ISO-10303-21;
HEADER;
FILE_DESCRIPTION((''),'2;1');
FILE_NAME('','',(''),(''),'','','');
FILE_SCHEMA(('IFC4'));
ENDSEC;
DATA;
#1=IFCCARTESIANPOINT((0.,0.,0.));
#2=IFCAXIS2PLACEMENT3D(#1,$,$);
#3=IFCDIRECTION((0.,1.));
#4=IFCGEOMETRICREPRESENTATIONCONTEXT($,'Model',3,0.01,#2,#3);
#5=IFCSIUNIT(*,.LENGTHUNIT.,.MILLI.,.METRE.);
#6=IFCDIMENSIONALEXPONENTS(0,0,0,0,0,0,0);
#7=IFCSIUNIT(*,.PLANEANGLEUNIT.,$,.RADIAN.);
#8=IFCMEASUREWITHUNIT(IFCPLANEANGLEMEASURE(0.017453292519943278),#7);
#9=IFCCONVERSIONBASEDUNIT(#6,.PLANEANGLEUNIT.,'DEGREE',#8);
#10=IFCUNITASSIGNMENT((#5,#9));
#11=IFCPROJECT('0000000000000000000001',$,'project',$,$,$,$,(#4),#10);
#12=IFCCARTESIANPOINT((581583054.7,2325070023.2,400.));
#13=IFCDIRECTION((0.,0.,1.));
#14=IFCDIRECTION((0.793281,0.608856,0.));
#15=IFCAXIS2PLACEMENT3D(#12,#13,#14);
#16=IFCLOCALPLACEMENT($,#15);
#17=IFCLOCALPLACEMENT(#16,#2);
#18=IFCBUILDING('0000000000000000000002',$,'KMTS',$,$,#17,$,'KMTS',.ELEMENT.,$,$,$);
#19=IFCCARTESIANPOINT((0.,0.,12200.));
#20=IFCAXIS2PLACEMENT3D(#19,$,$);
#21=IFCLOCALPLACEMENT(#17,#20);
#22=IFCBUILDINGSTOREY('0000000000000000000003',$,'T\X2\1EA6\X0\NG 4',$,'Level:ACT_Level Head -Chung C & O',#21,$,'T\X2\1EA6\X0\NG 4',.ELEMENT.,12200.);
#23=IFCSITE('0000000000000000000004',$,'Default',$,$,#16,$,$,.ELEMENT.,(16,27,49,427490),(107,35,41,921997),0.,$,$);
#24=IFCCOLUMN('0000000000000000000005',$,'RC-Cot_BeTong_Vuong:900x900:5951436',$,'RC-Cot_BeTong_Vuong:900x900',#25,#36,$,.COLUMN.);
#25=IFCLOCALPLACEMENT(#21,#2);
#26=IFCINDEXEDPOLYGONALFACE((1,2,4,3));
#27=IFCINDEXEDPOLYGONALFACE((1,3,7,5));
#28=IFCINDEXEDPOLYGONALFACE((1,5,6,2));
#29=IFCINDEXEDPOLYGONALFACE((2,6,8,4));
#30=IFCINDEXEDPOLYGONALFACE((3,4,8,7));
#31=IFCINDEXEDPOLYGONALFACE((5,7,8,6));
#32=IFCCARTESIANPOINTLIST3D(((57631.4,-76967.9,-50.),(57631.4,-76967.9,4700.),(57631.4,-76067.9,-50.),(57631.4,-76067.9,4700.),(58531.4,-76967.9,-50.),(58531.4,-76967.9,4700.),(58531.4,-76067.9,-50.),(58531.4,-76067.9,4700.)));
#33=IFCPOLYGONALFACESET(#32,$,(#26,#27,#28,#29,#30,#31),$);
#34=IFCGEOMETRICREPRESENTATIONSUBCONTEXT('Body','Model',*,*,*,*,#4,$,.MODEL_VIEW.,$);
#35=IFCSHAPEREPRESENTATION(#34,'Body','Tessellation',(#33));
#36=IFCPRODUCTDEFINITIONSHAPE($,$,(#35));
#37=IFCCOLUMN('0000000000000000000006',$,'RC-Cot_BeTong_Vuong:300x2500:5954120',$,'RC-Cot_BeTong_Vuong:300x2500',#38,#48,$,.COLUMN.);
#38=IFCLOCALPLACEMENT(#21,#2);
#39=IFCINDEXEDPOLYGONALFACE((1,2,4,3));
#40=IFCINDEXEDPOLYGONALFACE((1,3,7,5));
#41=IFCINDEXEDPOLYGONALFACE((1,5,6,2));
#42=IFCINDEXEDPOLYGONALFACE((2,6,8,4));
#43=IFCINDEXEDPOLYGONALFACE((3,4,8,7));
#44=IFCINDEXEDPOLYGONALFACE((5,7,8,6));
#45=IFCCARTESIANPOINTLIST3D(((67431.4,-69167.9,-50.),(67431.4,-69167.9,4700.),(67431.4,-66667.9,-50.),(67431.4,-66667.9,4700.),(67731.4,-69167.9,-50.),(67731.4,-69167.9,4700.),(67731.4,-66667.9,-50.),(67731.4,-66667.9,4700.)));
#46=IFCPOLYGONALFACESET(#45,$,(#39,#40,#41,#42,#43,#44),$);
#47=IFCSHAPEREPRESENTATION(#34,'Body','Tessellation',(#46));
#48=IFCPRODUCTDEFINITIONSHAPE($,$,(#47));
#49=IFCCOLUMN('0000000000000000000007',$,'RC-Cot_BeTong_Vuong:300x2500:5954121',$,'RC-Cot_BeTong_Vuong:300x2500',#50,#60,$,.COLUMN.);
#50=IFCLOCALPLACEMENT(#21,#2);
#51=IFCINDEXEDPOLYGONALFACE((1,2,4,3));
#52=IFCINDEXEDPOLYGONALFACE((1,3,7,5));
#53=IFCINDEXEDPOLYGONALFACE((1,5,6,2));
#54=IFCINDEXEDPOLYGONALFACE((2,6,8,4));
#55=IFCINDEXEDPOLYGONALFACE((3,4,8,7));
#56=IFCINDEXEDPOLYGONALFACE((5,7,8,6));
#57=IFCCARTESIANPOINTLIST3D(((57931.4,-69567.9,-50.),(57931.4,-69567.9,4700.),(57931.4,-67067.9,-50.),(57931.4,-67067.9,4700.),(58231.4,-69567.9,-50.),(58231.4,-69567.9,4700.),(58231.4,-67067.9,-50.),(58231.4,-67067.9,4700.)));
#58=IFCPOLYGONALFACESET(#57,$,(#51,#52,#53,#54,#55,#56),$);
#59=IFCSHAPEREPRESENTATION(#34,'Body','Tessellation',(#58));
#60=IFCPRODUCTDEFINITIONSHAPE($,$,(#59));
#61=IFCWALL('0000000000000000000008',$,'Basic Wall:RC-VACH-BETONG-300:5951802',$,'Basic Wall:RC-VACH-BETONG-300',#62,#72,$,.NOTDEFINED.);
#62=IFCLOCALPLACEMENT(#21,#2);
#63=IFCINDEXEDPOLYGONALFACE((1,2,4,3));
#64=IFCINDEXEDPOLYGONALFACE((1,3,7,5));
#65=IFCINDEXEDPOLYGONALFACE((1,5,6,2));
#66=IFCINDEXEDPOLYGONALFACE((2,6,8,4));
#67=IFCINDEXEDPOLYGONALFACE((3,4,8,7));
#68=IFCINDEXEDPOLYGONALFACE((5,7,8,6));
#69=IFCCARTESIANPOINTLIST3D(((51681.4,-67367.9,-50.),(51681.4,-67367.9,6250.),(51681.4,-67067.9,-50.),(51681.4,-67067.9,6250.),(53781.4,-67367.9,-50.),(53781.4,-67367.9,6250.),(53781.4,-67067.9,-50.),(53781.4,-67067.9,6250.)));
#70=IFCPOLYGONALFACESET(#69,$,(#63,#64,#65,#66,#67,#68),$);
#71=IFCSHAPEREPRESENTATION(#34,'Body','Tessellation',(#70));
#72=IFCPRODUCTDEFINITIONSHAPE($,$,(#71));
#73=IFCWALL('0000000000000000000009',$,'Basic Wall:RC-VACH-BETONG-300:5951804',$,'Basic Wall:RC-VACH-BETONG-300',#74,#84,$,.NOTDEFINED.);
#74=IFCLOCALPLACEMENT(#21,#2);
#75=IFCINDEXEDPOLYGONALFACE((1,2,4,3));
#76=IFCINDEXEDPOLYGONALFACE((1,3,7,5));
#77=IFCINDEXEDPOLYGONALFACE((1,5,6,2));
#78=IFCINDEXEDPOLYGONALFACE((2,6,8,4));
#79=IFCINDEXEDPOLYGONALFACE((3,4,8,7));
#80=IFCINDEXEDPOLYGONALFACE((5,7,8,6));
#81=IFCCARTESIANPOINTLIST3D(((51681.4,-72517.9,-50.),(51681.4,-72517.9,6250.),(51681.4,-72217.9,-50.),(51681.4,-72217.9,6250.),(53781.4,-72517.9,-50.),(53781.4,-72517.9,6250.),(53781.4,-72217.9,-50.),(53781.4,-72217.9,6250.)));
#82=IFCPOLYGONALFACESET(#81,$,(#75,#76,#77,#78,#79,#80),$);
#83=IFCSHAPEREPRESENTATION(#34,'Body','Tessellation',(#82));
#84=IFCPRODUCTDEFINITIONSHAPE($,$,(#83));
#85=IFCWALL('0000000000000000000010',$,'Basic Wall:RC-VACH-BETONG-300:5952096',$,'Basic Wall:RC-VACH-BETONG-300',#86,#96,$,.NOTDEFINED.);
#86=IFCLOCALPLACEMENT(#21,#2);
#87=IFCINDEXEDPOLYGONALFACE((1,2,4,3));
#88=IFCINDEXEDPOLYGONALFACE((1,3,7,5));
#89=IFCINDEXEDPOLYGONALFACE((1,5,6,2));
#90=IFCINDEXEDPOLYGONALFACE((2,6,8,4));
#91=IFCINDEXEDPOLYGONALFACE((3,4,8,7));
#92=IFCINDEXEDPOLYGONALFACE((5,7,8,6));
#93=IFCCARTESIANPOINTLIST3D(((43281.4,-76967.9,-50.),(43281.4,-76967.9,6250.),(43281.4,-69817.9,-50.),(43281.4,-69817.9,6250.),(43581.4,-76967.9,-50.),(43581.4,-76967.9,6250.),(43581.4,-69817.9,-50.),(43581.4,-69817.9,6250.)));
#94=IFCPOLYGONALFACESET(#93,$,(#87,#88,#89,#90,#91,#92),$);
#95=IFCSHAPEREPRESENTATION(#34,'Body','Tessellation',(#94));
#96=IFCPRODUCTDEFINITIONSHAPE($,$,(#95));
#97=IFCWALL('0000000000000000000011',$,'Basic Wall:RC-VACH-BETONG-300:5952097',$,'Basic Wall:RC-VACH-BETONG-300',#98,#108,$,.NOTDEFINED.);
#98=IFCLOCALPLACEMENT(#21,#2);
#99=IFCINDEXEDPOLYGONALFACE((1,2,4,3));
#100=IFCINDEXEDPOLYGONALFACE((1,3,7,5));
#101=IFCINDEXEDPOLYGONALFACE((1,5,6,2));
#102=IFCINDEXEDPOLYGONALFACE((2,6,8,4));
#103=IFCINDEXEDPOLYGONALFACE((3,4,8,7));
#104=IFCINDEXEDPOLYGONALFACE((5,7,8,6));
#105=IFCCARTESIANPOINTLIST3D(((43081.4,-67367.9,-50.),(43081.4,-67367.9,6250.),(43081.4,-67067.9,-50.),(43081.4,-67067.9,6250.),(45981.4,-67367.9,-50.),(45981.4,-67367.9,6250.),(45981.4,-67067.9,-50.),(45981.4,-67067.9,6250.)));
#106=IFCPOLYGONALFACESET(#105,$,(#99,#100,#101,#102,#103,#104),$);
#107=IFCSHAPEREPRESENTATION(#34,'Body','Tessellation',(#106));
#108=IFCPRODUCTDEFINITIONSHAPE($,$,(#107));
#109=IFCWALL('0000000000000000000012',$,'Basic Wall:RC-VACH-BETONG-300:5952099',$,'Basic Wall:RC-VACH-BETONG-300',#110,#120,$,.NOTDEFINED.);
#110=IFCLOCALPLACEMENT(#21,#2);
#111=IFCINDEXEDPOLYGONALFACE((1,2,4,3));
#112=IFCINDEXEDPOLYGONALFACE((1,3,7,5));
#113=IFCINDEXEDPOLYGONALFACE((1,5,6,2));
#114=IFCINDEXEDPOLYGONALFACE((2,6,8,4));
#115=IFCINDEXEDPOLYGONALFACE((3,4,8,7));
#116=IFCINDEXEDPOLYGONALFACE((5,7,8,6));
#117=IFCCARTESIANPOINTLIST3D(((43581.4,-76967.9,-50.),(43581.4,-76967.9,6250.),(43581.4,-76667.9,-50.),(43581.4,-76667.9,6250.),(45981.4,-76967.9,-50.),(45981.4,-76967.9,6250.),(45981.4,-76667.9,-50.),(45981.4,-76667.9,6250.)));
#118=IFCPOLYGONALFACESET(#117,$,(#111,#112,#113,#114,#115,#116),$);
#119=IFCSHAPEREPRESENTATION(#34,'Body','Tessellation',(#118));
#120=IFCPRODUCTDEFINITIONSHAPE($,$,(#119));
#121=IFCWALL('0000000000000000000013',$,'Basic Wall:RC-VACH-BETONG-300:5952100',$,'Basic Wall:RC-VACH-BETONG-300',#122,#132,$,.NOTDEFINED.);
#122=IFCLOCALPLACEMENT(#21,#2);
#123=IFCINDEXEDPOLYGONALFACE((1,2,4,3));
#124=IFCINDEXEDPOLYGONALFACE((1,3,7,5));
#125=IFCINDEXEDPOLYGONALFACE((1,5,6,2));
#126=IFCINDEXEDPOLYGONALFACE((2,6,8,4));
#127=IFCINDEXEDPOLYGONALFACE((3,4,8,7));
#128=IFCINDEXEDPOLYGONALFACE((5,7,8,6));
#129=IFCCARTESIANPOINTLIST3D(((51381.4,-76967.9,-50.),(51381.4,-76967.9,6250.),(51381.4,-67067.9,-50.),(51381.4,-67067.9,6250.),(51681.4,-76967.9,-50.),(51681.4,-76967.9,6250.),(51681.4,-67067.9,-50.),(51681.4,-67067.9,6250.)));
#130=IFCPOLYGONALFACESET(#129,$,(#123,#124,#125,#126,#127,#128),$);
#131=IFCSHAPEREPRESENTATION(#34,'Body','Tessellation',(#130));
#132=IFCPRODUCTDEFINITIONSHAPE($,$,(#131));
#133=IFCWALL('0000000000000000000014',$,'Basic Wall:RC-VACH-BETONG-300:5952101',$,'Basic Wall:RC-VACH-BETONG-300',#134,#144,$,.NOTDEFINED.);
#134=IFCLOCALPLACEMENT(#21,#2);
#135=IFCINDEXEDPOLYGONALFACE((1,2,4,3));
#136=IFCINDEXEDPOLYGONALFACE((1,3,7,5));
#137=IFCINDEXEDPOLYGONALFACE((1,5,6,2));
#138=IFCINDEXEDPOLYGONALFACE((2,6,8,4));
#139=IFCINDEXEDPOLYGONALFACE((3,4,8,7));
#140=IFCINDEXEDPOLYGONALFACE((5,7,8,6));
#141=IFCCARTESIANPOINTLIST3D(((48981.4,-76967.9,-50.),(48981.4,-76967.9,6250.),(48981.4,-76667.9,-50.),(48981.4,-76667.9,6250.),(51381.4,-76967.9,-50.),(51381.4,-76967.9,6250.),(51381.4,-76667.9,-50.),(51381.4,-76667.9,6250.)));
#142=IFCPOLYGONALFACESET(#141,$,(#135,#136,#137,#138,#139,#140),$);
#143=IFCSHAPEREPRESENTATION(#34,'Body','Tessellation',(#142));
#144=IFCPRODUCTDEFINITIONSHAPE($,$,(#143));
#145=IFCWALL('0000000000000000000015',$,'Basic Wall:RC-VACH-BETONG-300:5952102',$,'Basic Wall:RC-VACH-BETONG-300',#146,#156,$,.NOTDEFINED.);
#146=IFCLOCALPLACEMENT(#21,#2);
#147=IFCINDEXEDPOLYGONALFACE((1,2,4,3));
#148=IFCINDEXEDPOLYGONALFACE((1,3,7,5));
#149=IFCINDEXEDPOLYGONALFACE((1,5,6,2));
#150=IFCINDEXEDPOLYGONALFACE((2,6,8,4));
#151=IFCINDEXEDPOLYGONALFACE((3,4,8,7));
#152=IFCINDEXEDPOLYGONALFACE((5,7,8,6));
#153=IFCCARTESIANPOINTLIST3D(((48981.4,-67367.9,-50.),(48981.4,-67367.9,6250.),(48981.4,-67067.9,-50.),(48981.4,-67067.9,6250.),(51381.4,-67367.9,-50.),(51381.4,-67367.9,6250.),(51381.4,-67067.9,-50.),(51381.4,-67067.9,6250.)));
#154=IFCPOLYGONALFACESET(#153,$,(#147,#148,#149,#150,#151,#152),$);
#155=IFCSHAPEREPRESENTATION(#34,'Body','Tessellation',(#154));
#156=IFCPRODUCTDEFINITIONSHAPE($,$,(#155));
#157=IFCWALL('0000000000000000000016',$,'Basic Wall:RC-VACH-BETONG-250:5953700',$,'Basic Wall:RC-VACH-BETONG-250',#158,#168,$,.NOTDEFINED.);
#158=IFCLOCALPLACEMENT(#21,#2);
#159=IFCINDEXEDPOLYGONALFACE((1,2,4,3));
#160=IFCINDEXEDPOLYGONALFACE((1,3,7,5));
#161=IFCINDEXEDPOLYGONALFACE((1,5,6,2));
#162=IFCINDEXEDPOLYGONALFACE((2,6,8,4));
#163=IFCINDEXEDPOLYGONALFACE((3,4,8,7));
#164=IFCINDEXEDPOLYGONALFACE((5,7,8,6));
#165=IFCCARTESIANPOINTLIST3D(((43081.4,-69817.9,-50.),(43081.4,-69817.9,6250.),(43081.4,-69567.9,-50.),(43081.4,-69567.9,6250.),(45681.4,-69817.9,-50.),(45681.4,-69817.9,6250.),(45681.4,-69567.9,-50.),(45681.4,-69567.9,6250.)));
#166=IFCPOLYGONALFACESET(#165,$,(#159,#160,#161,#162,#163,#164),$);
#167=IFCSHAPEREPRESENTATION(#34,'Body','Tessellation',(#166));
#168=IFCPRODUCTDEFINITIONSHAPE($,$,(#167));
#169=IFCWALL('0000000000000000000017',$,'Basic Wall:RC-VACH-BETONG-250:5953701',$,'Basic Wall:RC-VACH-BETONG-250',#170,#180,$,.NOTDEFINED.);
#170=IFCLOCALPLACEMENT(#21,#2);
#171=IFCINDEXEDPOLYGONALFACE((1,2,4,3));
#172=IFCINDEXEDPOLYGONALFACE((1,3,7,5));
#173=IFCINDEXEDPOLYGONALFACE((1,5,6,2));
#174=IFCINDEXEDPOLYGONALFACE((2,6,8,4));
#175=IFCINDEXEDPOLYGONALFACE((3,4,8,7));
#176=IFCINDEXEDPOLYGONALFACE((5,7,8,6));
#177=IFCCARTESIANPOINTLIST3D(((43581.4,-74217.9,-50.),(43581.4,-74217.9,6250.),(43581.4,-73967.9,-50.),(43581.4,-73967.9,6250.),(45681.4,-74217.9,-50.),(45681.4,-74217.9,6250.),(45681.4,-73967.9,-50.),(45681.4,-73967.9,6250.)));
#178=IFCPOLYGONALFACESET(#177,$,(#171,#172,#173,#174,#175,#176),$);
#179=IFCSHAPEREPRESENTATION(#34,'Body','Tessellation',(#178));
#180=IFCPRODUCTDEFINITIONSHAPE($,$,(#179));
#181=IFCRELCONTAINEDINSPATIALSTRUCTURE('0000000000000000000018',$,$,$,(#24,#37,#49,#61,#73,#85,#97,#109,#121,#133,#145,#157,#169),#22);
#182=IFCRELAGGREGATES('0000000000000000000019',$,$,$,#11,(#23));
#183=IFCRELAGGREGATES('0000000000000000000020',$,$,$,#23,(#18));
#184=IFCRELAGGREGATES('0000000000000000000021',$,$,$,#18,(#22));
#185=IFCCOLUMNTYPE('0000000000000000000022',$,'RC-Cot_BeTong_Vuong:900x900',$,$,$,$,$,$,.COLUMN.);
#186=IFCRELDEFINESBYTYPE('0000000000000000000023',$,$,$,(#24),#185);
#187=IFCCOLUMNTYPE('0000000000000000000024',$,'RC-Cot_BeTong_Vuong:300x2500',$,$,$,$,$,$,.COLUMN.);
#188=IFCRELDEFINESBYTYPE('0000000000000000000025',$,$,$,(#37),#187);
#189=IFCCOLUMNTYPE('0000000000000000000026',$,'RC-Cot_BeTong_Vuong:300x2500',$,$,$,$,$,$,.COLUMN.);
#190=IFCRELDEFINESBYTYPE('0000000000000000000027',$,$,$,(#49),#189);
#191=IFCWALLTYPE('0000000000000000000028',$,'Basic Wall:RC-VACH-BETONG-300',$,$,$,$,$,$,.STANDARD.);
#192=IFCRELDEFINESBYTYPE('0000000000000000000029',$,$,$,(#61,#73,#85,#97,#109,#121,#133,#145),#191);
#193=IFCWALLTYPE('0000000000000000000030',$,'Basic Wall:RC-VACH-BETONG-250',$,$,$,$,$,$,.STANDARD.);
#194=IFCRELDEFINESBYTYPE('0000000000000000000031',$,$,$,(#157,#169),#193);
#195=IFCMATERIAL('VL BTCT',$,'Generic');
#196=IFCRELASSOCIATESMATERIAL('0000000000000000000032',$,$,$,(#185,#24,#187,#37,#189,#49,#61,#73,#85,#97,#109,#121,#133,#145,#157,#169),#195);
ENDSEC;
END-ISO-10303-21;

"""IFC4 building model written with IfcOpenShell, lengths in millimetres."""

from ifc_helpers import new_model, entity, si_unit, converted_unit, direction, frame, origin, place, context, subcontext, project, spatial, indexed_curve, outline, extrude, source, transform, mapped, material, type_object, type_shapes, element, save


model = new_model("IFC4")

# Units and contexts
model_context = context("Model", 3, precision=0.01, world=origin(), true_north=direction((0.0, 1.0)))
body_context = subcontext(model_context, "Body", "Model", "MODEL_VIEW")
ifc_project = project(units=[si_unit("LENGTHUNIT", "METRE", prefix="MILLI"), converted_unit("PLANEANGLEUNIT", "DEGREE", entity("IfcPlaneAngleMeasure", 0.017453292519943278), si_unit("PLANEANGLEUNIT", "RADIAN"), dimensions=[0, 0, 0, 0, 0, 0, 0])], contexts=[model_context])

# Site, building, storey
site_placement = place(None, frame((581583054.7, 2325070023.2, 400.0), z_axis=(0.0, 0.0, 1.0), x_axis=(0.793281, 0.608856, 0.0)))
site = spatial("IfcSite", under=ifc_project, at=site_placement, Name="Default", CompositionType="ELEMENT", RefLatitude=(16, 27, 49, 427490), RefLongitude=(107, 35, 41, 921997), RefElevation=0.0)
building_placement = place(site_placement, origin())
building = spatial("IfcBuilding", under=site, at=building_placement, Name="KMTS", LongName="KMTS", CompositionType="ELEMENT")
storey_placement = place(building_placement, frame((0.0, 0.0, 12200.0)))
storey = spatial("IfcBuildingStorey", under=building, at=storey_placement, Name="TẦNG 4", ObjectType="Level:ACT_Level Head -Chung C & O", LongName="TẦNG 4", CompositionType="ELEMENT", Elevation=12200.0)

# Columns
ifc_material_1 = material(Name="VL BTCT", Category="Generic")
column_type_1 = type_object("IfcColumnType", Name="RC-Cot_BeTong_Vuong:900x900", PredefinedType="COLUMN", material=ifc_material_1)
shared_shape_1 = source(origin(), body_context, "Body", "SweptSolid", [
    extrude(outline(indexed_curve([(-450.0, -450.0), (450.0, -450.0), (450.0, 450.0), (-450.0, 450.0), (-450.0, -450.0)], self_intersect=False)), frame((58081.4, -76517.9, 12150.0), z_axis=(0.0, 0.0, 1.0), x_axis=(-1.0, 0.0, 0.0)), (0.0, 0.0, 1.0), 4750.0),
])
type_shapes(column_type_1, [shared_shape_1])
column_1_placement = place(storey_placement, frame((0.0, 0.0, -12200.0)))
element("IfcColumn", 1, at=column_1_placement, inside=storey, type_object=column_type_1, material=ifc_material_1, Name="RC-Cot_BeTong_Vuong:900x900:5951436", ObjectType="RC-Cot_BeTong_Vuong:900x900", PredefinedType="COLUMN", context=body_context, shape_type="MappedRepresentation", body=[
    mapped(shared_shape_1, transform((0.0, 0.0, 0.0), scale=1.0)),
])
column_type_2 = type_object("IfcColumnType", Name="RC-Cot_BeTong_Vuong:300x2500", PredefinedType="COLUMN", material=ifc_material_1)
shared_shape_2 = source(origin(), body_context, "Body", "SweptSolid", [
    extrude(outline(indexed_curve([(-150.0, -1250.0), (150.0, -1250.0), (150.0, 1250.0), (-150.0, 1250.0), (-150.0, -1250.0)], self_intersect=False)), frame((67581.4, -67917.9, 12150.0), z_axis=(0.0, 0.0, 1.0), x_axis=(-1.0, 0.0, 0.0)), (0.0, 0.0, 1.0), 4750.0),
])
type_shapes(column_type_2, [shared_shape_2])
column_2_placement = place(storey_placement, frame((0.0, 0.0, -12200.0)))
element("IfcColumn", 2, at=column_2_placement, inside=storey, type_object=column_type_2, material=ifc_material_1, Name="RC-Cot_BeTong_Vuong:300x2500:5954120", ObjectType="RC-Cot_BeTong_Vuong:300x2500", PredefinedType="COLUMN", context=body_context, shape_type="MappedRepresentation", body=[
    mapped(shared_shape_2, transform((0.0, 0.0, 0.0), scale=1.0)),
])
column_type_3 = type_object("IfcColumnType", Name="RC-Cot_BeTong_Vuong:300x2500", PredefinedType="COLUMN", material=ifc_material_1)
shared_shape_3 = source(origin(), body_context, "Body", "SweptSolid", [
    extrude(outline(indexed_curve([(-150.0, -1250.0), (150.0, -1250.0), (150.0, 1250.0), (-150.0, 1250.0), (-150.0, -1250.0)], self_intersect=False)), frame((58081.4, -68317.9, 12150.0), z_axis=(0.0, 0.0, 1.0), x_axis=(-1.0, 0.0, 0.0)), (0.0, 0.0, 1.0), 4750.0),
])
type_shapes(column_type_3, [shared_shape_3])
column_3_placement = place(storey_placement, frame((0.0, 0.0, -12200.0)))
element("IfcColumn", 3, at=column_3_placement, inside=storey, type_object=column_type_3, material=ifc_material_1, Name="RC-Cot_BeTong_Vuong:300x2500:5954121", ObjectType="RC-Cot_BeTong_Vuong:300x2500", PredefinedType="COLUMN", context=body_context, shape_type="MappedRepresentation", body=[
    mapped(shared_shape_3, transform((0.0, 0.0, 0.0), scale=1.0)),
])

# Walls
wall_type_1 = type_object("IfcWallType", Name="Basic Wall:RC-VACH-BETONG-300", PredefinedType="STANDARD")
wall_1_placement = place(storey_placement, frame((53781.4, -67217.9, -50.0), z_axis=(0.0, 0.0, 1.0), x_axis=(-1.0, 0.0, 0.0)))
element("IfcWall", 4, at=wall_1_placement, inside=storey, type_object=wall_type_1, material=ifc_material_1, Name="Basic Wall:RC-VACH-BETONG-300:5951802", ObjectType="Basic Wall:RC-VACH-BETONG-300", PredefinedType="NOTDEFINED", context=body_context, shape_type="SweptSolid", body=[
    extrude(outline(indexed_curve([(2100.0, 150.0), (0.0, 150.0), (0.0, -150.0), (2100.0, -150.0), (2100.0, 150.0)], self_intersect=False)), origin(), (0.0, 0.0, 1.0), 6300.0),
])
wall_2_placement = place(storey_placement, frame((53781.4, -72367.9, -50.0), z_axis=(0.0, 0.0, 1.0), x_axis=(-1.0, 0.0, 0.0)))
element("IfcWall", 5, at=wall_2_placement, inside=storey, type_object=wall_type_1, material=ifc_material_1, Name="Basic Wall:RC-VACH-BETONG-300:5951804", ObjectType="Basic Wall:RC-VACH-BETONG-300", PredefinedType="NOTDEFINED", context=body_context, shape_type="SweptSolid", body=[
    extrude(outline(indexed_curve([(2100.0, 150.0), (0.0, 150.0), (0.0, -150.0), (2100.0, -150.0), (2100.0, 150.0)], self_intersect=False)), origin(), (0.0, 0.0, 1.0), 6300.0),
])
wall_3_placement = place(storey_placement, frame((43431.4, -69817.9, -50.0), z_axis=(0.0, 0.0, 1.0), x_axis=(0.0, -1.0, 0.0)))
element("IfcWall", 6, at=wall_3_placement, inside=storey, type_object=wall_type_1, material=ifc_material_1, Name="Basic Wall:RC-VACH-BETONG-300:5952096", ObjectType="Basic Wall:RC-VACH-BETONG-300", PredefinedType="NOTDEFINED", context=body_context, shape_type="SweptSolid", body=[
    extrude(outline(indexed_curve([(7150.0, 150.0), (0.0, 150.0), (0.0, -150.0), (7150.0, -150.0), (7150.0, 150.0)], self_intersect=False)), origin(), (0.0, 0.0, 1.0), 6300.0),
])
wall_4_placement = place(storey_placement, frame((45981.4, -67217.9, -50.0), z_axis=(0.0, 0.0, 1.0), x_axis=(-1.0, 0.0, 0.0)))
element("IfcWall", 7, at=wall_4_placement, inside=storey, type_object=wall_type_1, material=ifc_material_1, Name="Basic Wall:RC-VACH-BETONG-300:5952097", ObjectType="Basic Wall:RC-VACH-BETONG-300", PredefinedType="NOTDEFINED", context=body_context, shape_type="SweptSolid", body=[
    extrude(outline(indexed_curve([(2900.0, 150.0), (0.0, 150.0), (0.0, -150.0), (2900.0, -150.0), (2900.0, 150.0)], self_intersect=False)), origin(), (0.0, 0.0, 1.0), 6300.0),
])
wall_5_placement = place(storey_placement, frame((45981.4, -76817.9, -50.0), z_axis=(0.0, 0.0, 1.0), x_axis=(-1.0, 0.0, 0.0)))
element("IfcWall", 8, at=wall_5_placement, inside=storey, type_object=wall_type_1, material=ifc_material_1, Name="Basic Wall:RC-VACH-BETONG-300:5952099", ObjectType="Basic Wall:RC-VACH-BETONG-300", PredefinedType="NOTDEFINED", context=body_context, shape_type="SweptSolid", body=[
    extrude(outline(indexed_curve([(2400.0, 150.0), (0.0, 150.0), (0.0, -150.0), (2400.0, -150.0), (2400.0, 150.0)], self_intersect=False)), origin(), (0.0, 0.0, 1.0), 6300.0),
])
wall_6_placement = place(storey_placement, frame((51531.4, -67067.9, -50.0), z_axis=(0.0, 0.0, 1.0), x_axis=(0.0, -1.0, 0.0)))
element("IfcWall", 9, at=wall_6_placement, inside=storey, type_object=wall_type_1, material=ifc_material_1, Name="Basic Wall:RC-VACH-BETONG-300:5952100", ObjectType="Basic Wall:RC-VACH-BETONG-300", PredefinedType="NOTDEFINED", context=body_context, shape_type="SweptSolid", body=[
    extrude(outline(indexed_curve([(9900.0, 150.0), (0.0, 150.0), (0.0, -150.0), (9900.0, -150.0), (9900.0, 150.0)], self_intersect=False)), origin(), (0.0, 0.0, 1.0), 6300.0),
])
wall_7_placement = place(storey_placement, frame((51381.4, -76817.9, -50.0), z_axis=(0.0, 0.0, 1.0), x_axis=(-1.0, 0.0, 0.0)))
element("IfcWall", 10, at=wall_7_placement, inside=storey, type_object=wall_type_1, material=ifc_material_1, Name="Basic Wall:RC-VACH-BETONG-300:5952101", ObjectType="Basic Wall:RC-VACH-BETONG-300", PredefinedType="NOTDEFINED", context=body_context, shape_type="SweptSolid", body=[
    extrude(outline(indexed_curve([(2400.0, 150.0), (0.0, 150.0), (0.0, -150.0), (2400.0, -150.0), (2400.0, 150.0)], self_intersect=False)), origin(), (0.0, 0.0, 1.0), 6300.0),
])
wall_8_placement = place(storey_placement, frame((51381.4, -67217.9, -50.0), z_axis=(0.0, 0.0, 1.0), x_axis=(-1.0, 0.0, 0.0)))
element("IfcWall", 11, at=wall_8_placement, inside=storey, type_object=wall_type_1, material=ifc_material_1, Name="Basic Wall:RC-VACH-BETONG-300:5952102", ObjectType="Basic Wall:RC-VACH-BETONG-300", PredefinedType="NOTDEFINED", context=body_context, shape_type="SweptSolid", body=[
    extrude(outline(indexed_curve([(2400.0, 150.0), (0.0, 150.0), (0.0, -150.0), (2400.0, -150.0), (2400.0, 150.0)], self_intersect=False)), origin(), (0.0, 0.0, 1.0), 6300.0),
])
wall_type_2 = type_object("IfcWallType", Name="Basic Wall:RC-VACH-BETONG-250", PredefinedType="STANDARD")
wall_9_placement = place(storey_placement, frame((45681.4, -69692.9, -50.0), z_axis=(0.0, 0.0, 1.0), x_axis=(-1.0, 0.0, 0.0)))
element("IfcWall", 12, at=wall_9_placement, inside=storey, type_object=wall_type_2, material=ifc_material_1, Name="Basic Wall:RC-VACH-BETONG-250:5953700", ObjectType="Basic Wall:RC-VACH-BETONG-250", PredefinedType="NOTDEFINED", context=body_context, shape_type="SweptSolid", body=[
    extrude(outline(indexed_curve([(2600.0, 125.0), (0.0, 125.0), (0.0, -125.0), (2600.0, -125.0), (2600.0, 125.0)], self_intersect=False)), origin(), (0.0, 0.0, 1.0), 6300.0),
])
wall_10_placement = place(storey_placement, frame((45681.4, -74092.9, -50.0), z_axis=(0.0, 0.0, 1.0), x_axis=(-1.0, 0.0, 0.0)))
element("IfcWall", 13, at=wall_10_placement, inside=storey, type_object=wall_type_2, material=ifc_material_1, Name="Basic Wall:RC-VACH-BETONG-250:5953701", ObjectType="Basic Wall:RC-VACH-BETONG-250", PredefinedType="NOTDEFINED", context=body_context, shape_type="SweptSolid", body=[
    extrude(outline(indexed_curve([(2100.0, 125.0), (0.0, 125.0), (0.0, -125.0), (2100.0, -125.0), (2100.0, 125.0)], self_intersect=False)), origin(), (0.0, 0.0, 1.0), 6300.0),
])

save(model, "model.ifc")
